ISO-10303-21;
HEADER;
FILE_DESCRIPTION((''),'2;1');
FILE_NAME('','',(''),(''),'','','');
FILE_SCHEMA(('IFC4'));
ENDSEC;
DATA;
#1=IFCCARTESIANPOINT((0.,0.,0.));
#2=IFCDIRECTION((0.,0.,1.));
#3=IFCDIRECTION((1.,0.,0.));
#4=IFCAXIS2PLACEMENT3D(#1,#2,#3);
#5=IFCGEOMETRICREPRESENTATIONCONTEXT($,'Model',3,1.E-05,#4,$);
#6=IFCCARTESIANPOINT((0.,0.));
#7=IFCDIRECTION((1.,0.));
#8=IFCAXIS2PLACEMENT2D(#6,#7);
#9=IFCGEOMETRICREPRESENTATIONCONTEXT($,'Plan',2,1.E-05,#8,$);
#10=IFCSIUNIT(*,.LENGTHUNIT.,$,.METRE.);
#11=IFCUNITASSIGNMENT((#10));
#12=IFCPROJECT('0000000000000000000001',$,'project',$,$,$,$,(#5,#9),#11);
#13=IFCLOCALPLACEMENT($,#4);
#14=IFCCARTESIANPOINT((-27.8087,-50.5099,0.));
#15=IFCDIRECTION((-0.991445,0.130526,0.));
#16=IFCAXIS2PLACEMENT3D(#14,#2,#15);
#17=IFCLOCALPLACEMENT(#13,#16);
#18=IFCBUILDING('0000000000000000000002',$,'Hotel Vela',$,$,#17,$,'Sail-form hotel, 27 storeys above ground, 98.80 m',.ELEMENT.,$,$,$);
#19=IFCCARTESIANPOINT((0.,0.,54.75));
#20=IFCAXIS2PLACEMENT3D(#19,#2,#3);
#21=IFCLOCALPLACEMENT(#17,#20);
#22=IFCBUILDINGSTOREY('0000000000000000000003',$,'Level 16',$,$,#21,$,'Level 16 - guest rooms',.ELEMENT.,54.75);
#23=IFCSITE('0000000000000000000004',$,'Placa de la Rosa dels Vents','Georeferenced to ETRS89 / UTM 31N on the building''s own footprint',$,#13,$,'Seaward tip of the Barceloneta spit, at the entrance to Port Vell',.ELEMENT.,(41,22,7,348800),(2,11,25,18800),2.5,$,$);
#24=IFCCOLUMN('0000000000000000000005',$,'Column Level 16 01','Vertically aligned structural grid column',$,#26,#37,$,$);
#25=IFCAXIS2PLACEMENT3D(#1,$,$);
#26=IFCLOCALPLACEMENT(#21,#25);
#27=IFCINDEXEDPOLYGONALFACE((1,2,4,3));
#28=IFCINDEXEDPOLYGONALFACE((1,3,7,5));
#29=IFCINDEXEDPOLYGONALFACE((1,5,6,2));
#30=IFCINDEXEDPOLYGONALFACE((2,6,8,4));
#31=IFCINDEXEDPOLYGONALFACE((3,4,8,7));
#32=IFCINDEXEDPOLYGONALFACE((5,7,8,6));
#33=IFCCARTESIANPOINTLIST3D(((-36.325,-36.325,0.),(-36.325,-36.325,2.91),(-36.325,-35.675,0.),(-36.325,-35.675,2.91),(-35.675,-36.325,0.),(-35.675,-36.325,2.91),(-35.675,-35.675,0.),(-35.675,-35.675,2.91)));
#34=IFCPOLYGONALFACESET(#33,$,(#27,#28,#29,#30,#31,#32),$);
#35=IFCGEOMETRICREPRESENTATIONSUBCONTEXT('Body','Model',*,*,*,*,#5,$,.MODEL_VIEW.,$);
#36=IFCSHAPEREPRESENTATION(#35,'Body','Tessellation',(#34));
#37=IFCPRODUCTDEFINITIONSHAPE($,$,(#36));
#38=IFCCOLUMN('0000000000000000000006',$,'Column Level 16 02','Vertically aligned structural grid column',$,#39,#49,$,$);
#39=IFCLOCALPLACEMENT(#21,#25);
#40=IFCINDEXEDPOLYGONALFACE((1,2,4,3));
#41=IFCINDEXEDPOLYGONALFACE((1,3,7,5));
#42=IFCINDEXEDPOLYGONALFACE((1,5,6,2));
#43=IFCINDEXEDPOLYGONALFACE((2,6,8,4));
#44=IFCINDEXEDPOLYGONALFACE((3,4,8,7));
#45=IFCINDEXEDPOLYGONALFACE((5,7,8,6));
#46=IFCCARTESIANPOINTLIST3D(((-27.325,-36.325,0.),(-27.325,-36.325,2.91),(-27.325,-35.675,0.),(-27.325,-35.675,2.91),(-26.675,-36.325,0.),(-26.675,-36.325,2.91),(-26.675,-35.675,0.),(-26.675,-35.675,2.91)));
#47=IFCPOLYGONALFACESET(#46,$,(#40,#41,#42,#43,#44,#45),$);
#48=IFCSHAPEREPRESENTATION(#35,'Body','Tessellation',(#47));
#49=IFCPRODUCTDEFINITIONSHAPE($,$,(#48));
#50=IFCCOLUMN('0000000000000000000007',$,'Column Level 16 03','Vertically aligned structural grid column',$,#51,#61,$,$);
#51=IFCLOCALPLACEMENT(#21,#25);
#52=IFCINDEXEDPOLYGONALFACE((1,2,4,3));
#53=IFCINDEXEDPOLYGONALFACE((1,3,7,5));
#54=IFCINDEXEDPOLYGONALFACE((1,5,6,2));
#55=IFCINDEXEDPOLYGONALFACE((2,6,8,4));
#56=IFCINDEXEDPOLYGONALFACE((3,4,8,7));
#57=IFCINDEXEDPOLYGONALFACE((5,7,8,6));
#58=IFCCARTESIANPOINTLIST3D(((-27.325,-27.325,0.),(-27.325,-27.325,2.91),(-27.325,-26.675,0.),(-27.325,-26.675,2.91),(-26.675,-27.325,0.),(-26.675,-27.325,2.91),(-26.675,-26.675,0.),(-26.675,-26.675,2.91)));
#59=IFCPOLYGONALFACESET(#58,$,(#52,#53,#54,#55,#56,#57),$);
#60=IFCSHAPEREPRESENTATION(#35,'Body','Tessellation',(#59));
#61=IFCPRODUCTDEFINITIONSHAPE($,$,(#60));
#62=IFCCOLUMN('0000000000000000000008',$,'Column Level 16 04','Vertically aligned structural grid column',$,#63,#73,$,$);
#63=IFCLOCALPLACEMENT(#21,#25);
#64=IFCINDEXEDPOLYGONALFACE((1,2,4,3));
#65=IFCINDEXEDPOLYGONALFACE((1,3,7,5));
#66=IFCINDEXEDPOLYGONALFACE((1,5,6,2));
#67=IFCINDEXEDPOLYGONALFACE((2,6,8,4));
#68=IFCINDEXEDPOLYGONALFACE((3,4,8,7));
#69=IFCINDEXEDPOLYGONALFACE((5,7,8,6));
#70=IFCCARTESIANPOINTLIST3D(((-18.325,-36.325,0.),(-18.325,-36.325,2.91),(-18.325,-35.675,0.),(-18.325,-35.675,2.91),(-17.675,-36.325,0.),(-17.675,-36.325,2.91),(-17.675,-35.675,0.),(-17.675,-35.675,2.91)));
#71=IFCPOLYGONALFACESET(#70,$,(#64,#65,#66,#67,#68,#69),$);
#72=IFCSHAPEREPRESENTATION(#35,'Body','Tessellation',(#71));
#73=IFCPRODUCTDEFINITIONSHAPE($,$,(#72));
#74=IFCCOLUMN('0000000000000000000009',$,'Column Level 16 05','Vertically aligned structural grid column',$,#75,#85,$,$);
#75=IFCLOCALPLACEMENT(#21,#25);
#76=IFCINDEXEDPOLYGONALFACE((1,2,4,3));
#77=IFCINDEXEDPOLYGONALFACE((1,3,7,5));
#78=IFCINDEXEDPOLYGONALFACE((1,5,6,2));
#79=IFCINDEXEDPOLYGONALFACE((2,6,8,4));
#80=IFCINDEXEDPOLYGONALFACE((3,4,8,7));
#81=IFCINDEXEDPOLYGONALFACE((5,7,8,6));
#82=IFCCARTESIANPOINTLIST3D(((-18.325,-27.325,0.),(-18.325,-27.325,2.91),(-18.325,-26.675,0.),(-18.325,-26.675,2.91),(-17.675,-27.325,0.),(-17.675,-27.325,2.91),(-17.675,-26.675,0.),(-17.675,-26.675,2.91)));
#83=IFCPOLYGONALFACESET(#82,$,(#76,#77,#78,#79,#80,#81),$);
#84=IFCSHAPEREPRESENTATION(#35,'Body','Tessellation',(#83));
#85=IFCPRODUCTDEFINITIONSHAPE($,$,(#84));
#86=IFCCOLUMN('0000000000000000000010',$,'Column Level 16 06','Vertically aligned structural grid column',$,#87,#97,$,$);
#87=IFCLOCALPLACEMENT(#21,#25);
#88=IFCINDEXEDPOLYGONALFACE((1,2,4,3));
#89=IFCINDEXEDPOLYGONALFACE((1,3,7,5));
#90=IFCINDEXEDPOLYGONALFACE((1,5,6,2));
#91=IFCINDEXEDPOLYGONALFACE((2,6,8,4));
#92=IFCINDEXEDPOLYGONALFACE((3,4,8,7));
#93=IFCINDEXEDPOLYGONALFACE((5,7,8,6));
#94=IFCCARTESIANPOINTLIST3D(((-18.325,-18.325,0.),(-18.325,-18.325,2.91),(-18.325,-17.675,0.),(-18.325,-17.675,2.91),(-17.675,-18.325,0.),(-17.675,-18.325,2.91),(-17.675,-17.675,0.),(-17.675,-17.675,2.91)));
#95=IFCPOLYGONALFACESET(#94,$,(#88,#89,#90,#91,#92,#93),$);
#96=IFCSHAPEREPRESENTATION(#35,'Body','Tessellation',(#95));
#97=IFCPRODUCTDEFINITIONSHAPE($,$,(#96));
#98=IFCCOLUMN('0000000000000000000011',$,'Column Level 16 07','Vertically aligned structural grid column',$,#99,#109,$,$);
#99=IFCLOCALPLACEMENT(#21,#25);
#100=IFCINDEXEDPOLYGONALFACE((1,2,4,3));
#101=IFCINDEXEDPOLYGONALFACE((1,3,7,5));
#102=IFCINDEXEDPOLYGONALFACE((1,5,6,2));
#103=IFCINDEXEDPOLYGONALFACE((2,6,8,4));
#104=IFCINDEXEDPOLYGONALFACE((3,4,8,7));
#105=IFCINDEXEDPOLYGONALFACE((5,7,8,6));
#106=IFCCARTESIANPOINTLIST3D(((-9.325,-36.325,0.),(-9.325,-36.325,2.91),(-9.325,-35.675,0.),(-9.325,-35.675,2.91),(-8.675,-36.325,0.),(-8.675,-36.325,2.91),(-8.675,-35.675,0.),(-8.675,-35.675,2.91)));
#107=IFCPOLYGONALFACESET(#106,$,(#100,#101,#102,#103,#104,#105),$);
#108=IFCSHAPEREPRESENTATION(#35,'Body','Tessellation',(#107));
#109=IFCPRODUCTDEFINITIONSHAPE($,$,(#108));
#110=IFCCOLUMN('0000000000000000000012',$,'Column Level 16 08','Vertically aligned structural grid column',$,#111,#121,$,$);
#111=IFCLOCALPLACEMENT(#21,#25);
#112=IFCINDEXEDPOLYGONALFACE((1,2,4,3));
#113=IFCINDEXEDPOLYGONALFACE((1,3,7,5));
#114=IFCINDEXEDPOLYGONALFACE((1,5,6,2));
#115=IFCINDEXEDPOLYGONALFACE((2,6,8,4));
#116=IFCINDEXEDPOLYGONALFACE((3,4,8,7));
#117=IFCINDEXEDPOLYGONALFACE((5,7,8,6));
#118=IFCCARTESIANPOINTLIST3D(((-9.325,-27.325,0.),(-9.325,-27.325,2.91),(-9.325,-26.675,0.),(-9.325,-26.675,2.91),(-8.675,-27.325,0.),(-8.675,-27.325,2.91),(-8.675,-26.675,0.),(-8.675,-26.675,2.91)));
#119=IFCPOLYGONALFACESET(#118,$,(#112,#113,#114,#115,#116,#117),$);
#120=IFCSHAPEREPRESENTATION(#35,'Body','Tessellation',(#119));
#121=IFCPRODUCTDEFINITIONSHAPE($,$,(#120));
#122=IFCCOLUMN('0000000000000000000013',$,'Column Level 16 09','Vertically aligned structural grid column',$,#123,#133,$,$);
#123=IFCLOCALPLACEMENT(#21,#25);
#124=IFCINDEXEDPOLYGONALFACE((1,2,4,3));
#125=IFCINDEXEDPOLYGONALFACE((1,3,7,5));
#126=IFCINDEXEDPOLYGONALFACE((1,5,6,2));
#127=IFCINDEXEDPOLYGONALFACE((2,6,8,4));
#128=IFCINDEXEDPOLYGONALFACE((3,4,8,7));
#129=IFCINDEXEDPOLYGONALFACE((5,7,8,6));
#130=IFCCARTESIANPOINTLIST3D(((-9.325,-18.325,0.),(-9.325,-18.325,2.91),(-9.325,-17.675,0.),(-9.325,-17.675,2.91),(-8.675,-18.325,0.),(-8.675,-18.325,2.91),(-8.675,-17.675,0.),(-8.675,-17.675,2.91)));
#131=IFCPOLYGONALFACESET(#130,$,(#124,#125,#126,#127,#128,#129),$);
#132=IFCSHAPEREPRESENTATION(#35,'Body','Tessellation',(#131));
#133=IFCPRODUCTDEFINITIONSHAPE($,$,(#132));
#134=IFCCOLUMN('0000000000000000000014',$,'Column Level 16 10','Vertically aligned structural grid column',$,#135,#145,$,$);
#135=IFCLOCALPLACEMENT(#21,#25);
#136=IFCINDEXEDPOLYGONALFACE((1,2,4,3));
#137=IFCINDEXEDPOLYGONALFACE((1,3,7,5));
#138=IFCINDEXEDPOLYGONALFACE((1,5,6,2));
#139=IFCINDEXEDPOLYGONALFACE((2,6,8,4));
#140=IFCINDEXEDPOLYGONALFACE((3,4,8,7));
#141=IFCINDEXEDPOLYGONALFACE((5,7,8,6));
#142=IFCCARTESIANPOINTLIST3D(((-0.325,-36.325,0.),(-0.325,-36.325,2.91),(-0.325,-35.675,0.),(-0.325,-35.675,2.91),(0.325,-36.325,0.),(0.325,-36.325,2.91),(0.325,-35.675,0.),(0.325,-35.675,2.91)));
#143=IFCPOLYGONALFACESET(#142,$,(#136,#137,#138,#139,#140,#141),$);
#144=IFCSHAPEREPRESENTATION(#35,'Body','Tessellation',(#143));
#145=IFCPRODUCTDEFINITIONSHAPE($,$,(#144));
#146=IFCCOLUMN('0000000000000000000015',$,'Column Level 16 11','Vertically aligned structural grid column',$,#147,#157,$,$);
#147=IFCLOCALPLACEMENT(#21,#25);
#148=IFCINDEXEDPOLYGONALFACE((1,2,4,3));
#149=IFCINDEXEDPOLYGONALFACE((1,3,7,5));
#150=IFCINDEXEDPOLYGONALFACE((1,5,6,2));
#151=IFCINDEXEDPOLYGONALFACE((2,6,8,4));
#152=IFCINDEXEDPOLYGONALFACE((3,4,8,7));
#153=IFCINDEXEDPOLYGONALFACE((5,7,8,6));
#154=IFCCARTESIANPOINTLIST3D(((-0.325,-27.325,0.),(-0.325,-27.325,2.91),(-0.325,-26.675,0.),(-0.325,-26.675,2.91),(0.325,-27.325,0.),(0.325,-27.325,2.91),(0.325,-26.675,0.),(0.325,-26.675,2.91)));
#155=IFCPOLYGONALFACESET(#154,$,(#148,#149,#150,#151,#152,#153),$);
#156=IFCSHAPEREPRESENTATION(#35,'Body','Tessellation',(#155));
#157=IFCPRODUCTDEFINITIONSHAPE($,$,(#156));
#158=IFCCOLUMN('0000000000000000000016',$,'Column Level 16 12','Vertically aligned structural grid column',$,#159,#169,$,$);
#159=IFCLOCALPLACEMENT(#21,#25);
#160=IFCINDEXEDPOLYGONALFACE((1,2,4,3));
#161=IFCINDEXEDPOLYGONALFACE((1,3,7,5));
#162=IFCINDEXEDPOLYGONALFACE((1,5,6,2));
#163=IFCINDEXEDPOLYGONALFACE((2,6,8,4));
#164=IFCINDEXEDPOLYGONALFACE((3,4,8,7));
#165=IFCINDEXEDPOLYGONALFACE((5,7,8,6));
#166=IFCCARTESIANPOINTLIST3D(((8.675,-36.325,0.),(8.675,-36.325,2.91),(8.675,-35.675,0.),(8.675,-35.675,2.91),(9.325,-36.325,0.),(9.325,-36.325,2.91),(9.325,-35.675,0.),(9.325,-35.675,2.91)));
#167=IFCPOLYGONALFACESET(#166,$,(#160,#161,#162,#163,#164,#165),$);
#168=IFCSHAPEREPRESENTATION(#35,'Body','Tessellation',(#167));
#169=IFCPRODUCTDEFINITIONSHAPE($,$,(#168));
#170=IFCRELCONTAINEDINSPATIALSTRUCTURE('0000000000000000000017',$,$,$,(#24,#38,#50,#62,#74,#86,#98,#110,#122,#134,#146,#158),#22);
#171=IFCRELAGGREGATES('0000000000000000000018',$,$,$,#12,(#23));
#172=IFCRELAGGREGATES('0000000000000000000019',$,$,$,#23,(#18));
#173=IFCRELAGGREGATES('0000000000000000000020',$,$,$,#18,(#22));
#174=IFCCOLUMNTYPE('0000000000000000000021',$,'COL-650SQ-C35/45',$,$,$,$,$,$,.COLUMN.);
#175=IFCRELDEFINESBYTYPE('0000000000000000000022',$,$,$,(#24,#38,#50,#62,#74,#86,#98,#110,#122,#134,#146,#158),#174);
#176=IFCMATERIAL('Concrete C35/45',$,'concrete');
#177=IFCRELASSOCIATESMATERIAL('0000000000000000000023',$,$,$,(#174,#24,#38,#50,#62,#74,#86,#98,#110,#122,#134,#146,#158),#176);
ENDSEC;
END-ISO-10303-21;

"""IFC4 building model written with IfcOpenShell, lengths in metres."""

from ifc_helpers import new_model, si_unit, frame, origin_with_axes, origin_2d_with_axis, place, context, subcontext, project, spatial, line, indexed_curve, rectangle, outline, extrude, material, material_profile, profile_set, profile_usage, type_object, element, save


model = new_model("IFC4")

# Units and contexts
model_context = context("Model", 3, precision=1e-05, world=origin_with_axes())
plan_context = context("Plan", 2, precision=1e-05, world=origin_2d_with_axis())
body_context = subcontext(model_context, "Body", "Model", "MODEL_VIEW")
ifc_project = project(units=[si_unit("LENGTHUNIT", "METRE")], contexts=[model_context, plan_context])

# Site, building, storey
site_placement = place(None, origin_with_axes())
site = spatial("IfcSite", under=ifc_project, at=site_placement, Name="Placa de la Rosa dels Vents", Description="Georeferenced to ETRS89 / UTM 31N on the building's own footprint", LongName="Seaward tip of the Barceloneta spit, at the entrance to Port Vell", CompositionType="ELEMENT", RefLatitude=(41, 22, 7, 348800), RefLongitude=(2, 11, 25, 18800), RefElevation=2.5)
building_placement = place(site_placement, frame((-27.8087, -50.5099, 0.0), z_axis=(0.0, 0.0, 1.0), x_axis=(-0.991445, 0.130526, 0.0)))
building = spatial("IfcBuilding", under=site, at=building_placement, Name="Hotel Vela", LongName="Sail-form hotel, 27 storeys above ground, 98.80 m", CompositionType="ELEMENT")
storey_placement = place(building_placement, frame((0.0, 0.0, 54.75), z_axis=(0.0, 0.0, 1.0), x_axis=(1.0, 0.0, 0.0)))
storey = spatial("IfcBuildingStorey", under=building, at=storey_placement, Name="Level 16", LongName="Level 16 - guest rooms", CompositionType="ELEMENT", Elevation=54.75)

# Columns
ifc_material = material(Name="Concrete C35/45", Category="concrete")
ifc_material_profile = material_profile(ifc_material, rectangle(XDim=0.65, YDim=0.65))
ifc_profile_set = profile_set([ifc_material_profile], Name="COL-650SQ-C35/45")
ifc_profile_usage_1 = profile_usage(ifc_profile_set)
column_type = type_object("IfcColumnType", Name="COL-650SQ-C35/45", PredefinedType="COLUMN", material=ifc_profile_set)
column_1_placement = place(storey_placement, frame((-36.325, -36.325, 0.0), z_axis=(0.0, 0.0, 1.0), x_axis=(1.0, 0.0, 0.0)))
element("IfcColumn", 1, at=column_1_placement, inside=storey, type_object=column_type, material=ifc_profile_usage_1, Name="Column Level 16 01", Description="Vertically aligned structural grid column", context=body_context, shape_type="SweptSolid", body=[
    extrude(outline(indexed_curve([(0.0, 0.0), (0.65, 0.0), (0.65, 0.65), (0.0, 0.65)], segments=[line(1, 2, 3, 4, 1)])), origin_with_axes(), (0.0, 0.0, 1.0), 2.91),
])
ifc_profile_usage_2 = profile_usage(ifc_profile_set)
column_2_placement = place(storey_placement, frame((-27.325, -36.325, 0.0), z_axis=(0.0, 0.0, 1.0), x_axis=(1.0, 0.0, 0.0)))
element("IfcColumn", 2, at=column_2_placement, inside=storey, type_object=column_type, material=ifc_profile_usage_2, Name="Column Level 16 02", Description="Vertically aligned structural grid column", context=body_context, shape_type="SweptSolid", body=[
    extrude(outline(indexed_curve([(0.0, 0.0), (0.65, 0.0), (0.65, 0.65), (0.0, 0.65)], segments=[line(1, 2, 3, 4, 1)])), origin_with_axes(), (0.0, 0.0, 1.0), 2.91),
])
ifc_profile_usage_3 = profile_usage(ifc_profile_set)
column_3_placement = place(storey_placement, frame((-27.325, -27.325, 0.0), z_axis=(0.0, 0.0, 1.0), x_axis=(1.0, 0.0, 0.0)))
element("IfcColumn", 3, at=column_3_placement, inside=storey, type_object=column_type, material=ifc_profile_usage_3, Name="Column Level 16 03", Description="Vertically aligned structural grid column", context=body_context, shape_type="SweptSolid", body=[
    extrude(outline(indexed_curve([(0.0, 0.0), (0.65, 0.0), (0.65, 0.65), (0.0, 0.65)], segments=[line(1, 2, 3, 4, 1)])), origin_with_axes(), (0.0, 0.0, 1.0), 2.91),
])
ifc_profile_usage_4 = profile_usage(ifc_profile_set)
column_4_placement = place(storey_placement, frame((-18.325, -36.325, 0.0), z_axis=(0.0, 0.0, 1.0), x_axis=(1.0, 0.0, 0.0)))
element("IfcColumn", 4, at=column_4_placement, inside=storey, type_object=column_type, material=ifc_profile_usage_4, Name="Column Level 16 04", Description="Vertically aligned structural grid column", context=body_context, shape_type="SweptSolid", body=[
    extrude(outline(indexed_curve([(0.0, 0.0), (0.65, 0.0), (0.65, 0.65), (0.0, 0.65)], segments=[line(1, 2, 3, 4, 1)])), origin_with_axes(), (0.0, 0.0, 1.0), 2.91),
])
ifc_profile_usage_5 = profile_usage(ifc_profile_set)
column_5_placement = place(storey_placement, frame((-18.325, -27.325, 0.0), z_axis=(0.0, 0.0, 1.0), x_axis=(1.0, 0.0, 0.0)))
element("IfcColumn", 5, at=column_5_placement, inside=storey, type_object=column_type, material=ifc_profile_usage_5, Name="Column Level 16 05", Description="Vertically aligned structural grid column", context=body_context, shape_type="SweptSolid", body=[
    extrude(outline(indexed_curve([(0.0, 0.0), (0.65, 0.0), (0.65, 0.65), (0.0, 0.65)], segments=[line(1, 2, 3, 4, 1)])), origin_with_axes(), (0.0, 0.0, 1.0), 2.91),
])
ifc_profile_usage_6 = profile_usage(ifc_profile_set)
column_6_placement = place(storey_placement, frame((-18.325, -18.325, 0.0), z_axis=(0.0, 0.0, 1.0), x_axis=(1.0, 0.0, 0.0)))
element("IfcColumn", 6, at=column_6_placement, inside=storey, type_object=column_type, material=ifc_profile_usage_6, Name="Column Level 16 06", Description="Vertically aligned structural grid column", context=body_context, shape_type="SweptSolid", body=[
    extrude(outline(indexed_curve([(0.0, 0.0), (0.65, 0.0), (0.65, 0.65), (0.0, 0.65)], segments=[line(1, 2, 3, 4, 1)])), origin_with_axes(), (0.0, 0.0, 1.0), 2.91),
])
ifc_profile_usage_7 = profile_usage(ifc_profile_set)
column_7_placement = place(storey_placement, frame((-9.325, -36.325, 0.0), z_axis=(0.0, 0.0, 1.0), x_axis=(1.0, 0.0, 0.0)))
element("IfcColumn", 7, at=column_7_placement, inside=storey, type_object=column_type, material=ifc_profile_usage_7, Name="Column Level 16 07", Description="Vertically aligned structural grid column", context=body_context, shape_type="SweptSolid", body=[
    extrude(outline(indexed_curve([(0.0, 0.0), (0.65, 0.0), (0.65, 0.65), (0.0, 0.65)], segments=[line(1, 2, 3, 4, 1)])), origin_with_axes(), (0.0, 0.0, 1.0), 2.91),
])
ifc_profile_usage_8 = profile_usage(ifc_profile_set)
column_8_placement = place(storey_placement, frame((-9.325, -27.325, 0.0), z_axis=(0.0, 0.0, 1.0), x_axis=(1.0, 0.0, 0.0)))
element("IfcColumn", 8, at=column_8_placement, inside=storey, type_object=column_type, material=ifc_profile_usage_8, Name="Column Level 16 08", Description="Vertically aligned structural grid column", context=body_context, shape_type="SweptSolid", body=[
    extrude(outline(indexed_curve([(0.0, 0.0), (0.65, 0.0), (0.65, 0.65), (0.0, 0.65)], segments=[line(1, 2, 3, 4, 1)])), origin_with_axes(), (0.0, 0.0, 1.0), 2.91),
])
ifc_profile_usage_9 = profile_usage(ifc_profile_set)
column_9_placement = place(storey_placement, frame((-9.325, -18.325, 0.0), z_axis=(0.0, 0.0, 1.0), x_axis=(1.0, 0.0, 0.0)))
element("IfcColumn", 9, at=column_9_placement, inside=storey, type_object=column_type, material=ifc_profile_usage_9, Name="Column Level 16 09", Description="Vertically aligned structural grid column", context=body_context, shape_type="SweptSolid", body=[
    extrude(outline(indexed_curve([(0.0, 0.0), (0.65, 0.0), (0.65, 0.65), (0.0, 0.65)], segments=[line(1, 2, 3, 4, 1)])), origin_with_axes(), (0.0, 0.0, 1.0), 2.91),
])
ifc_profile_usage_10 = profile_usage(ifc_profile_set)
column_10_placement = place(storey_placement, frame((-0.325, -36.325, 0.0), z_axis=(0.0, 0.0, 1.0), x_axis=(1.0, 0.0, 0.0)))
element("IfcColumn", 10, at=column_10_placement, inside=storey, type_object=column_type, material=ifc_profile_usage_10, Name="Column Level 16 10", Description="Vertically aligned structural grid column", context=body_context, shape_type="SweptSolid", body=[
    extrude(outline(indexed_curve([(0.0, 0.0), (0.65, 0.0), (0.65, 0.65), (0.0, 0.65)], segments=[line(1, 2, 3, 4, 1)])), origin_with_axes(), (0.0, 0.0, 1.0), 2.91),
])
ifc_profile_usage_11 = profile_usage(ifc_profile_set)
column_11_placement = place(storey_placement, frame((-0.325, -27.325, 0.0), z_axis=(0.0, 0.0, 1.0), x_axis=(1.0, 0.0, 0.0)))
element("IfcColumn", 11, at=column_11_placement, inside=storey, type_object=column_type, material=ifc_profile_usage_11, Name="Column Level 16 11", Description="Vertically aligned structural grid column", context=body_context, shape_type="SweptSolid", body=[
    extrude(outline(indexed_curve([(0.0, 0.0), (0.65, 0.0), (0.65, 0.65), (0.0, 0.65)], segments=[line(1, 2, 3, 4, 1)])), origin_with_axes(), (0.0, 0.0, 1.0), 2.91),
])
ifc_profile_usage_12 = profile_usage(ifc_profile_set)
column_12_placement = place(storey_placement, frame((8.675, -36.325, 0.0), z_axis=(0.0, 0.0, 1.0), x_axis=(1.0, 0.0, 0.0)))
element("IfcColumn", 12, at=column_12_placement, inside=storey, type_object=column_type, material=ifc_profile_usage_12, Name="Column Level 16 12", Description="Vertically aligned structural grid column", context=body_context, shape_type="SweptSolid", body=[
    extrude(outline(indexed_curve([(0.0, 0.0), (0.65, 0.0), (0.65, 0.65), (0.0, 0.65)], segments=[line(1, 2, 3, 4, 1)])), origin_with_axes(), (0.0, 0.0, 1.0), 2.91),
])

save(model, "model.ifc")
